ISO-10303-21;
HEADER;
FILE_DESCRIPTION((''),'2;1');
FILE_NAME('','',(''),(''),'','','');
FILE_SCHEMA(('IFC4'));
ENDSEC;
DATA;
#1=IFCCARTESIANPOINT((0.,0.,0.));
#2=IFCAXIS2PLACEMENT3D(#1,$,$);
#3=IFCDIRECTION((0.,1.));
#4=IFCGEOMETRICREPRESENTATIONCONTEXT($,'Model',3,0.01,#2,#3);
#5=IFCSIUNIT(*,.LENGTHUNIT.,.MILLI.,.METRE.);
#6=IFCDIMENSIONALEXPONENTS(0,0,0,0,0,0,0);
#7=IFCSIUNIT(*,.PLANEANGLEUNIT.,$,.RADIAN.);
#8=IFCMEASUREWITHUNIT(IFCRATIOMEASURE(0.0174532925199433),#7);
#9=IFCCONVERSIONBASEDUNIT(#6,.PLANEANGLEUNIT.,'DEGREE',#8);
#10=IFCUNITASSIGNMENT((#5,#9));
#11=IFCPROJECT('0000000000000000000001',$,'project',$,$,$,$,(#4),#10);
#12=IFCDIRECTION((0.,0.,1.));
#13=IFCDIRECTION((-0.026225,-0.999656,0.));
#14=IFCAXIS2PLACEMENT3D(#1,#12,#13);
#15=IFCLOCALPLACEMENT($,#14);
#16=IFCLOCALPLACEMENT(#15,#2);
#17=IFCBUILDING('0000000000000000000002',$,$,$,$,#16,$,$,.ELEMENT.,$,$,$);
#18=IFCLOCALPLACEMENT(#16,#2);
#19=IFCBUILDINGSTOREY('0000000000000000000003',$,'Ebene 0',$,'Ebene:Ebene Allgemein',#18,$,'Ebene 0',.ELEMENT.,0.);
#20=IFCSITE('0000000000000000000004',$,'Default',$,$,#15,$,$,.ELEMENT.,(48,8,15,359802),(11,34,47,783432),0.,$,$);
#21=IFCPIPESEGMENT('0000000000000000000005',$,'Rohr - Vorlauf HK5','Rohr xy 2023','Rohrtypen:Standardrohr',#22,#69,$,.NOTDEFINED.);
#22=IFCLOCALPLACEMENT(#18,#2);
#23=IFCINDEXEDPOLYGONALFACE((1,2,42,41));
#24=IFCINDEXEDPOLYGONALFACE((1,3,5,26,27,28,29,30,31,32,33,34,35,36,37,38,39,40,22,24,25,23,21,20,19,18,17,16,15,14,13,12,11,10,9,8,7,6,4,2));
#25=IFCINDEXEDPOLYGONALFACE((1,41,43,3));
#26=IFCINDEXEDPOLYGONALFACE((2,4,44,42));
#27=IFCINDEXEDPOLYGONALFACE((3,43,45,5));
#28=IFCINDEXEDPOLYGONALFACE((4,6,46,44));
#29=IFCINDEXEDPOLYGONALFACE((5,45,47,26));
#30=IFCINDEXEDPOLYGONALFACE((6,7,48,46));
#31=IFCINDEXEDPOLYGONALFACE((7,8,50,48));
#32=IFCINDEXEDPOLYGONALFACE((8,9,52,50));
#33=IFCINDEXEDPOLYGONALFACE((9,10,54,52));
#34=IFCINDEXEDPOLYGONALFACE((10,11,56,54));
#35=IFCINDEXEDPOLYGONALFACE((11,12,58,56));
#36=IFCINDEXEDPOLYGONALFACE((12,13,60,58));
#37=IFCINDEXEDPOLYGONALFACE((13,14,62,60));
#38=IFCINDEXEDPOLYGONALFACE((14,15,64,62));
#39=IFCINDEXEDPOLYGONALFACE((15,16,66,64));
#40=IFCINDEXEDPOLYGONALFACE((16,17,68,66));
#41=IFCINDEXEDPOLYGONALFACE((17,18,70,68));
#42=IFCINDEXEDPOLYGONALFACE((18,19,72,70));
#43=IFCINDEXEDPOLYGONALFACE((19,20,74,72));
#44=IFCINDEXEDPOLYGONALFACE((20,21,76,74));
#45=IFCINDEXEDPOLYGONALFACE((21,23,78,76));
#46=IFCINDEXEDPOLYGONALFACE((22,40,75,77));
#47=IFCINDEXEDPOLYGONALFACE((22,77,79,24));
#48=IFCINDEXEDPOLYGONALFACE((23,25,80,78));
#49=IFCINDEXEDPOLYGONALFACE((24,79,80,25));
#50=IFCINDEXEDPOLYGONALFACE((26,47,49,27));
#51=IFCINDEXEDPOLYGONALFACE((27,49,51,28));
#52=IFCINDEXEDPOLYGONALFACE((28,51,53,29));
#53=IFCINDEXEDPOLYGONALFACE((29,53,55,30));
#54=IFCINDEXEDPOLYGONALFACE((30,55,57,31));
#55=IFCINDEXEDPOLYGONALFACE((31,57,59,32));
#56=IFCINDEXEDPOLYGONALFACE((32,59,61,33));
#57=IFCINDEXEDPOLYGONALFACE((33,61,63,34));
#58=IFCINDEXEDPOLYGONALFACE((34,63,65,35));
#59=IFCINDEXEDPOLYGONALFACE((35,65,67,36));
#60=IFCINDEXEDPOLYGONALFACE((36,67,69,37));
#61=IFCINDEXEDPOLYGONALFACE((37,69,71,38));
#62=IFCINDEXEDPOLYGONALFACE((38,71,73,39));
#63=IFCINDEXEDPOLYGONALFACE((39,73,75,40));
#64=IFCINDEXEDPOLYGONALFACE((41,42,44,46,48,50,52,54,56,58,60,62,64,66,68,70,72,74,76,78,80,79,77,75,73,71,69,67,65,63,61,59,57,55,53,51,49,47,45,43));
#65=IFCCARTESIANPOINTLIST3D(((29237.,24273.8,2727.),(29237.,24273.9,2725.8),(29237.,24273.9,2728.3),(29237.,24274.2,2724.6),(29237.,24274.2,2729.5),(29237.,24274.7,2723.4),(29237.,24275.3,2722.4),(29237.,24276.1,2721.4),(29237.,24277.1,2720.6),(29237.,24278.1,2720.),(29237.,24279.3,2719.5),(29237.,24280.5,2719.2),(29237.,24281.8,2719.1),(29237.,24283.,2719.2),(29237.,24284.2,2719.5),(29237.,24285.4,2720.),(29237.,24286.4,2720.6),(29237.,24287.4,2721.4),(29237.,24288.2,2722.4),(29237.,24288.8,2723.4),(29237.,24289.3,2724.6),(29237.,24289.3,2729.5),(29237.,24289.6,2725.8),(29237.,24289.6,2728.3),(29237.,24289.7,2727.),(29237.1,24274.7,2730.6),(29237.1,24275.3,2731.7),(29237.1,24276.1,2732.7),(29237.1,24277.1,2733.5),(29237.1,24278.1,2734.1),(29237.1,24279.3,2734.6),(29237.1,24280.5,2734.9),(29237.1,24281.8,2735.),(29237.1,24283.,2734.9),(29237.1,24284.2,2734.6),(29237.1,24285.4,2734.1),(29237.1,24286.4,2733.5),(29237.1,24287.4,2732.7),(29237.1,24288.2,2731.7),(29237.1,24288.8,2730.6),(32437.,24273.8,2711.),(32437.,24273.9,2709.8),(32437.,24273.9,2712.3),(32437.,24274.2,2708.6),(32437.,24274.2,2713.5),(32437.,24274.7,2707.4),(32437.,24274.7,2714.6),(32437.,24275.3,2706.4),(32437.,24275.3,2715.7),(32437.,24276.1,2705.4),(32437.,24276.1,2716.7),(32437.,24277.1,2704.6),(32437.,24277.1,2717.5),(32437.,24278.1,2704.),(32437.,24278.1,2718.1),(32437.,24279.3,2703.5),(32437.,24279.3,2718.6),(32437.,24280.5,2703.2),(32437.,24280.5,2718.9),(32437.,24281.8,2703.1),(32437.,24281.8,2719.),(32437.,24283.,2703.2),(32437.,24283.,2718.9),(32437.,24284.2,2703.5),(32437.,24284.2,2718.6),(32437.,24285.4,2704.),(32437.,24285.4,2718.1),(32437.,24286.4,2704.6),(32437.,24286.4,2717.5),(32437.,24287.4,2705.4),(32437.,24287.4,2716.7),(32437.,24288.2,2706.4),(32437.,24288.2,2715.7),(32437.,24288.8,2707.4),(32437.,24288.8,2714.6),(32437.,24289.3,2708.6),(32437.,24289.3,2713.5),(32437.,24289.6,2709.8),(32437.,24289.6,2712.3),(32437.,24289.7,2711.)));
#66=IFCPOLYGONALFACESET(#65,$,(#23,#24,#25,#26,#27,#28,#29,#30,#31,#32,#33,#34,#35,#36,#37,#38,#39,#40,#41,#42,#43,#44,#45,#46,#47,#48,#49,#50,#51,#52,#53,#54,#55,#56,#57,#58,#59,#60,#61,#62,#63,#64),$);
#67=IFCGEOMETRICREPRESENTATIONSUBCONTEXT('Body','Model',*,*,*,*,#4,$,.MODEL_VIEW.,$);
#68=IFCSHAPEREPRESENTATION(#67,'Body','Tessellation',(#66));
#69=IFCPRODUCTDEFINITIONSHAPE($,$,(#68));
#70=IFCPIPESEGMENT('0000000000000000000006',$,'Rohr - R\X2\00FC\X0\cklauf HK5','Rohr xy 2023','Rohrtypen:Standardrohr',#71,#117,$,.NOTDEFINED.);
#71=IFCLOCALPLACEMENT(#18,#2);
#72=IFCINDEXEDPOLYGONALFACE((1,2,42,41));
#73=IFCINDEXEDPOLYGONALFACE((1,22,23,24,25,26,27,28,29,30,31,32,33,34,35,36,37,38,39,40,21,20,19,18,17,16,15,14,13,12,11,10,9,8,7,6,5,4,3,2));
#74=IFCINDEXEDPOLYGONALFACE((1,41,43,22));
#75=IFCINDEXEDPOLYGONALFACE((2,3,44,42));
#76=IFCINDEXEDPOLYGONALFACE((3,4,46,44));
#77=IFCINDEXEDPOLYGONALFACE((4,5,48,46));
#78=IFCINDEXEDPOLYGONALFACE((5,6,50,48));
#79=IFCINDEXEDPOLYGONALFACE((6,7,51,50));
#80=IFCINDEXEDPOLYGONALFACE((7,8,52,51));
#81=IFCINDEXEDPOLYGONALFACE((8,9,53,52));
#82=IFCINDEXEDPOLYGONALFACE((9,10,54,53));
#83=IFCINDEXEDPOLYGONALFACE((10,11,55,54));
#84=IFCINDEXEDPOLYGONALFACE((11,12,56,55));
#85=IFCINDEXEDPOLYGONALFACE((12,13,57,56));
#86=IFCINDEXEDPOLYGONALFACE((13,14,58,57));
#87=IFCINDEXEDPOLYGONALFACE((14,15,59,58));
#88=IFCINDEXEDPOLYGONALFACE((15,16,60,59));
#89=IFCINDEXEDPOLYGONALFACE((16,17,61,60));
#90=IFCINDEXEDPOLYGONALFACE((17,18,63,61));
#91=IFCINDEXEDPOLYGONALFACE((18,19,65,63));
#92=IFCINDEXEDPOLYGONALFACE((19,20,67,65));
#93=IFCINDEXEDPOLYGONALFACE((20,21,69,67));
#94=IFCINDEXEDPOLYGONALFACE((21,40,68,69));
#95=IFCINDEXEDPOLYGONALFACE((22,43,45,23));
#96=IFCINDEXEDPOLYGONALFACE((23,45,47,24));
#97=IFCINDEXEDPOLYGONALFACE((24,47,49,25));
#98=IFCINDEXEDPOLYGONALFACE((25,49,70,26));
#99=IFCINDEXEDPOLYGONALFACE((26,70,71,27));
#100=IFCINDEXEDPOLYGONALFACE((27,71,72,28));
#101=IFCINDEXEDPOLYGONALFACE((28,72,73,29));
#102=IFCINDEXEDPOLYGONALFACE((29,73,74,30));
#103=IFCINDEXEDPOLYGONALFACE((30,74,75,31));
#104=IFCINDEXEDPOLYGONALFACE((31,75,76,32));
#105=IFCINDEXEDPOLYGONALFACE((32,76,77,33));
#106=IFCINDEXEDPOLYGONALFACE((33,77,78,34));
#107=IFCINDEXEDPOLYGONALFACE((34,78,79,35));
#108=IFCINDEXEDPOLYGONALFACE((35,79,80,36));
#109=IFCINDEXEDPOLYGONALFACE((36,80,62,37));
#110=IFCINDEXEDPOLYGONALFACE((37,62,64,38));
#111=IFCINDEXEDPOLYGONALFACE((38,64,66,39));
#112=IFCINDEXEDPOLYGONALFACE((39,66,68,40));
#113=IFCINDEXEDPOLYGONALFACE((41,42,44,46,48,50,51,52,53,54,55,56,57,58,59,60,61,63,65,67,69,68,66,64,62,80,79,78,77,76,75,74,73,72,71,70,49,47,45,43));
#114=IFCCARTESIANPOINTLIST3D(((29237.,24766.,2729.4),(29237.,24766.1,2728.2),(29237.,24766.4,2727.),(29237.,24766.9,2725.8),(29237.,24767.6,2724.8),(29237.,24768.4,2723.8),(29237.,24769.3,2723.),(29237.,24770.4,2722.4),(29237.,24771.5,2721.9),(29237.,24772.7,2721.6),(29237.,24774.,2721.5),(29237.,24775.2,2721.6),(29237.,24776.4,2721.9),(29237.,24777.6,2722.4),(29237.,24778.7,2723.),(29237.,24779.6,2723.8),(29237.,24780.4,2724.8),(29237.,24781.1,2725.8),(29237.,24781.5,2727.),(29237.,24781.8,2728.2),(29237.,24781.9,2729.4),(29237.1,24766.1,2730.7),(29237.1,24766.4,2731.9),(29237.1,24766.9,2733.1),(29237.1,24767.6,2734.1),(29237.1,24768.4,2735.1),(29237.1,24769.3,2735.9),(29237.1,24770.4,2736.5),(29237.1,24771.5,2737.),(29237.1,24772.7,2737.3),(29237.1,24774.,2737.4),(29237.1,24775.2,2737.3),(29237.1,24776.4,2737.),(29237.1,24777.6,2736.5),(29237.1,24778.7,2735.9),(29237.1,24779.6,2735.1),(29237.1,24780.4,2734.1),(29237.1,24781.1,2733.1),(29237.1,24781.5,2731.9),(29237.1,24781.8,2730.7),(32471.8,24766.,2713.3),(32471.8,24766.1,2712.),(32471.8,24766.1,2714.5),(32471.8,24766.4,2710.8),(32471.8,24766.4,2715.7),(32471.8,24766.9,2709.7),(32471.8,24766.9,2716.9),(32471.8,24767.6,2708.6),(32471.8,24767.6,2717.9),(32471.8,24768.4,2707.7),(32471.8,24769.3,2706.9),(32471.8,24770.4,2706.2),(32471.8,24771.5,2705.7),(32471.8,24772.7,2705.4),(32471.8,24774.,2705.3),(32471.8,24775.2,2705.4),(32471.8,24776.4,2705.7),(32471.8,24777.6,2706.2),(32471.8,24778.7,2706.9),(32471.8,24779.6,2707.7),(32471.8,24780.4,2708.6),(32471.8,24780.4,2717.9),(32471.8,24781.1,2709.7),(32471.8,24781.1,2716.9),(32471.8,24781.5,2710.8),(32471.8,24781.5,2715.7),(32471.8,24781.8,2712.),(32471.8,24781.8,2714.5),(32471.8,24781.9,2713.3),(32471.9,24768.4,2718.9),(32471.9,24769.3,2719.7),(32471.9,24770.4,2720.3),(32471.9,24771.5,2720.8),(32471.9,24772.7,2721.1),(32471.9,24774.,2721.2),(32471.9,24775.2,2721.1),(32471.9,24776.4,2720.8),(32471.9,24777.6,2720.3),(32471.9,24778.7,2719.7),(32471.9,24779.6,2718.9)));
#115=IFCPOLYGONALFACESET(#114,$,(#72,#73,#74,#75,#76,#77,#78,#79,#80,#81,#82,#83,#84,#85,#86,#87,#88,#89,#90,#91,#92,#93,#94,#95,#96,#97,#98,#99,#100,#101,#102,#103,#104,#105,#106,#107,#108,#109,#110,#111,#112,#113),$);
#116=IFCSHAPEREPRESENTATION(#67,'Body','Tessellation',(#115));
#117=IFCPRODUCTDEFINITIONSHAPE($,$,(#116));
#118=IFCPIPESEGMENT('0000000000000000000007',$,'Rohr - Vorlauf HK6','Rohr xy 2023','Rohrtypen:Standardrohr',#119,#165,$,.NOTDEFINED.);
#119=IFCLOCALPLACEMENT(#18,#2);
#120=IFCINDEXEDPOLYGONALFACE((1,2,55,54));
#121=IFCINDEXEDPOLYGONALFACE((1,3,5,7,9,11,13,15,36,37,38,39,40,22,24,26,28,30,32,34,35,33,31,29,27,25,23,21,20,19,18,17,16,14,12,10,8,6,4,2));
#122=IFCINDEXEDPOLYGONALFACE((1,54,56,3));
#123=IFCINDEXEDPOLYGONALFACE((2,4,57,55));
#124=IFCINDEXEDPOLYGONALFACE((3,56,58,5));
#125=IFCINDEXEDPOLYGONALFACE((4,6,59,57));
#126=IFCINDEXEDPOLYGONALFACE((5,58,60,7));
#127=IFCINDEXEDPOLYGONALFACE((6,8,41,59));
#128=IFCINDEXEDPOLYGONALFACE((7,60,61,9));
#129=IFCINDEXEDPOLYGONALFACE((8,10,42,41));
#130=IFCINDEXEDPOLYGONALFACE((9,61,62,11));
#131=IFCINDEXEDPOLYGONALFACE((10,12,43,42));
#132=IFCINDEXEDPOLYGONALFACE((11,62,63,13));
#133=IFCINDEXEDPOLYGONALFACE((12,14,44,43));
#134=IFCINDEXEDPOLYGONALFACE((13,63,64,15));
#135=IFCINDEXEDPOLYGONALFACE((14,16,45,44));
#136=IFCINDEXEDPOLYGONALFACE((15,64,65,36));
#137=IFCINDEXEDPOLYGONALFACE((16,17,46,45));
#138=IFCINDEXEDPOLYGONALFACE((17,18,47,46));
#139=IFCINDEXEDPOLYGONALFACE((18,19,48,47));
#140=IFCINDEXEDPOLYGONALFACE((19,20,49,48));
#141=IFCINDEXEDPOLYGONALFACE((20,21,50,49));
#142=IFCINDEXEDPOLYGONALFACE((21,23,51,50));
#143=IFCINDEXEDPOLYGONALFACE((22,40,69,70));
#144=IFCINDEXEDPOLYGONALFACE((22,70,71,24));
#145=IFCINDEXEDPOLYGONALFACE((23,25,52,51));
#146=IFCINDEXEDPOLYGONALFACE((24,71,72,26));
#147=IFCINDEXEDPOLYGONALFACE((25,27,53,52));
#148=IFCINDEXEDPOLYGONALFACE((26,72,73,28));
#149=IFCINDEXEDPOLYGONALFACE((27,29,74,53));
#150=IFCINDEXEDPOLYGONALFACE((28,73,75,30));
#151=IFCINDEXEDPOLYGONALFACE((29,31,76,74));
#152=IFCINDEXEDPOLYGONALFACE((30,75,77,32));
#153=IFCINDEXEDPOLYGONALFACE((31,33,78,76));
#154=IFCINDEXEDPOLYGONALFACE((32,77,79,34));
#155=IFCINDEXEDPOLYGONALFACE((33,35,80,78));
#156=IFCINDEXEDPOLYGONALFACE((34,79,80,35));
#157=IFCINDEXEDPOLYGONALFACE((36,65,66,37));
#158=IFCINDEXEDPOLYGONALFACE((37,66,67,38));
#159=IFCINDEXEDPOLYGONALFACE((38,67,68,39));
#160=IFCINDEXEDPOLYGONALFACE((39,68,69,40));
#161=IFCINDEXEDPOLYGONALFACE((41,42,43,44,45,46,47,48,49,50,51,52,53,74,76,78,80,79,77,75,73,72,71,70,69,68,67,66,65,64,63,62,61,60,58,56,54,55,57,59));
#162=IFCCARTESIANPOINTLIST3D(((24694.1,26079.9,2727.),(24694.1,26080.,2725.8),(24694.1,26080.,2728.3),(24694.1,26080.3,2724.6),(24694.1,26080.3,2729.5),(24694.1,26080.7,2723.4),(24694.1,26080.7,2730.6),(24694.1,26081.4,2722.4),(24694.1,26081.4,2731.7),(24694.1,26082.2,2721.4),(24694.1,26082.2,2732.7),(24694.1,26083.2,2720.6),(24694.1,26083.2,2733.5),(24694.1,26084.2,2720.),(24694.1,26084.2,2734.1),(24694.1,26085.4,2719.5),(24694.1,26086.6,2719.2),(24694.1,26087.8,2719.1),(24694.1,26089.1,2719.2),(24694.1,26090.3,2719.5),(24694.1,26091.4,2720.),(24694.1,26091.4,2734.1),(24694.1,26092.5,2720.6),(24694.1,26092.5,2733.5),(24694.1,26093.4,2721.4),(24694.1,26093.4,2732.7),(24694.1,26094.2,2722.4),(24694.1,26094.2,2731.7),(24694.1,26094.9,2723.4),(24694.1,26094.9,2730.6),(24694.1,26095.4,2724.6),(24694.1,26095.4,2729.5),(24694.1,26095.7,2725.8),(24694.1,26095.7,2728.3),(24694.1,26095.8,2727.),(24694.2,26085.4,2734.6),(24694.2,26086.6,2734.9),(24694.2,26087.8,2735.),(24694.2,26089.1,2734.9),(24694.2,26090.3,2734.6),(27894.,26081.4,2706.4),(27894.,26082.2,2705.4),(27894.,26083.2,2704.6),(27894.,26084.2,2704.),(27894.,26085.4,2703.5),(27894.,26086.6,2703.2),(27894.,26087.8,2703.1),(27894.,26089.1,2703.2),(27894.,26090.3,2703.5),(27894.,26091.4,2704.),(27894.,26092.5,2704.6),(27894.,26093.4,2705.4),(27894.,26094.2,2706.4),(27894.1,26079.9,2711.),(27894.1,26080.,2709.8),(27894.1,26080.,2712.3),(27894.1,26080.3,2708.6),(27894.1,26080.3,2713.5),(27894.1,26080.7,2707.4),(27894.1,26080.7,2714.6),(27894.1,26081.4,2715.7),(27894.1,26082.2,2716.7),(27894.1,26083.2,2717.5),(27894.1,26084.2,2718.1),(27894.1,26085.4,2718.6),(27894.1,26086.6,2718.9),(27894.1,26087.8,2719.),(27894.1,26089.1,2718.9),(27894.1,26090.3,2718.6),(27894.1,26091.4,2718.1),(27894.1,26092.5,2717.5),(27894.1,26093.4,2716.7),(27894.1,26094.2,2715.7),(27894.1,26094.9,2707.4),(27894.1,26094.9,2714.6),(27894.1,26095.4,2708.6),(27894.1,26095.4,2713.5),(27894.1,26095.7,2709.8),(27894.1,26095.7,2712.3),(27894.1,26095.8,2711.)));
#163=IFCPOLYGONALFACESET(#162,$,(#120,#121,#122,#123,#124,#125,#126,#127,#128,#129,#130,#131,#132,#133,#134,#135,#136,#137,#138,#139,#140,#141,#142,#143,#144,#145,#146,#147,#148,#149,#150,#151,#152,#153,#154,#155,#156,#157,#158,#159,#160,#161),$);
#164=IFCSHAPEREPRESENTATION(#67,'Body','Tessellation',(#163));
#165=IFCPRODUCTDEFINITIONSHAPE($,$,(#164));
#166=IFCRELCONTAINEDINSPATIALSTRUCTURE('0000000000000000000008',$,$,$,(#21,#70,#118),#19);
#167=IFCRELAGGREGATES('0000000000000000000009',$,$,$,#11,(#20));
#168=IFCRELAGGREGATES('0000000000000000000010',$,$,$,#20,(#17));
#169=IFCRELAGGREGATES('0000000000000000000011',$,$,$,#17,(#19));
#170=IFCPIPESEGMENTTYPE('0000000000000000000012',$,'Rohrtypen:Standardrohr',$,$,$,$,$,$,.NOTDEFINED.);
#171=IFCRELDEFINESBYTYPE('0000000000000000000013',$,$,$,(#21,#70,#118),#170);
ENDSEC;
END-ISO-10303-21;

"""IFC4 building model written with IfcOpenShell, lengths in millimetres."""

from ifc_helpers import new_model, entity, si_unit, converted_unit, direction, frame, origin, place, context, subcontext, project, spatial, indexed_curve, outline, extrude, type_object, element, save


model = new_model("IFC4")

# Units and contexts
model_context = context("Model", 3, precision=0.01, world=origin(), true_north=direction((0.0, 1.0)))
body_context = subcontext(model_context, "Body", "Model", "MODEL_VIEW")
ifc_project = project(units=[si_unit("LENGTHUNIT", "METRE", prefix="MILLI"), converted_unit("PLANEANGLEUNIT", "DEGREE", entity("IfcRatioMeasure", 0.0174532925199433), si_unit("PLANEANGLEUNIT", "RADIAN"), dimensions=[0, 0, 0, 0, 0, 0, 0])], contexts=[model_context])

# Site, building, storey
site_placement = place(None, frame((0.0, 0.0, 0.0), z_axis=(0.0, 0.0, 1.0), x_axis=(-0.026225, -0.999656, 0.0)))
site = spatial("IfcSite", under=ifc_project, at=site_placement, Name="Default", CompositionType="ELEMENT", RefLatitude=(48, 8, 15, 359802), RefLongitude=(11, 34, 47, 783432), RefElevation=0.0)
building_placement = place(site_placement, origin())
building = spatial("IfcBuilding", under=site, at=building_placement, CompositionType="ELEMENT")
storey_placement = place(building_placement, origin())
storey = spatial("IfcBuildingStorey", under=building, at=storey_placement, Name="Ebene 0", ObjectType="Ebene:Ebene Allgemein", LongName="Ebene 0", CompositionType="ELEMENT", Elevation=0.0)

# Pipe segments
pipe_segment_type = type_object("IfcPipeSegmentType", Name="Rohrtypen:Standardrohr", PredefinedType="NOTDEFINED")
pipe_segment_1_placement = place(storey_placement, origin())
element("IfcPipeSegment", 1, at=pipe_segment_1_placement, inside=storey, type_object=pipe_segment_type, Name="Rohr - Vorlauf HK5", Description="Rohr xy 2023", ObjectType="Rohrtypen:Standardrohr", PredefinedType="NOTDEFINED", context=body_context, shape_type="SweptSolid", body=[
    extrude(outline(indexed_curve([(7.9, 0.0), (7.8, 1.2), (7.6, 2.5), (7.1, 3.6), (6.4, 4.7), (5.6, 5.6), (4.7, 6.4), (3.6, 7.1), (2.5, 7.6), (1.2, 7.8), (0.0, 7.9), (-1.2, 7.8), (-2.5, 7.6), (-3.6, 7.1), (-4.7, 6.4), (-5.6, 5.6), (-6.4, 4.7), (-7.1, 3.6), (-7.6, 2.5), (-7.8, 1.2), (-7.9, 0.0), (-7.8, -1.2), (-7.6, -2.5), (-7.1, -3.6), (-6.4, -4.7), (-5.6, -5.6), (-4.7, -6.4), (-3.6, -7.1), (-2.5, -7.6), (-1.2, -7.8), (0.0, -7.9), (1.2, -7.8), (2.5, -7.6), (3.6, -7.1), (4.7, -6.4), (5.6, -5.6), (6.4, -4.7), (7.1, -3.6), (7.6, -2.5), (7.8, -1.2), (7.9, 0.0)], self_intersect=False)), frame((32437.0, 24281.8, 2711.0), z_axis=(-0.999988, 0.0, 0.005), x_axis=(0.0, 1.0, 0.0)), (0.0, 0.0, 1.0), 3200.0),
])
pipe_segment_2_placement = place(storey_placement, origin())
element("IfcPipeSegment", 2, at=pipe_segment_2_placement, inside=storey, type_object=pipe_segment_type, Name="Rohr - Rücklauf HK5", Description="Rohr xy 2023", ObjectType="Rohrtypen:Standardrohr", PredefinedType="NOTDEFINED", context=body_context, shape_type="SweptSolid", body=[
    extrude(outline(indexed_curve([(7.9, 0.0), (7.8, 1.2), (7.6, 2.5), (7.1, 3.6), (6.4, 4.7), (5.6, 5.6), (4.7, 6.4), (3.6, 7.1), (2.5, 7.6), (1.2, 7.8), (0.0, 7.9), (-1.2, 7.8), (-2.5, 7.6), (-3.6, 7.1), (-4.7, 6.4), (-5.6, 5.6), (-6.4, 4.7), (-7.1, 3.6), (-7.6, 2.5), (-7.8, 1.2), (-7.9, 0.0), (-7.8, -1.2), (-7.6, -2.5), (-7.1, -3.6), (-6.4, -4.7), (-5.6, -5.6), (-4.7, -6.4), (-3.6, -7.1), (-2.5, -7.6), (-1.2, -7.8), (0.0, -7.9), (1.2, -7.8), (2.5, -7.6), (3.6, -7.1), (4.7, -6.4), (5.6, -5.6), (6.4, -4.7), (7.1, -3.6), (7.6, -2.5), (7.8, -1.2), (7.9, 0.0)], self_intersect=False)), frame((32471.8, 24774.0, 2713.3), z_axis=(-0.999988, 0.0, 0.005), x_axis=(0.0, 1.0, 0.0)), (0.0, 0.0, 1.0), 3234.8),
])
pipe_segment_3_placement = place(storey_placement, origin())
element("IfcPipeSegment", 3, at=pipe_segment_3_placement, inside=storey, type_object=pipe_segment_type, Name="Rohr - Vorlauf HK6", Description="Rohr xy 2023", ObjectType="Rohrtypen:Standardrohr", PredefinedType="NOTDEFINED", context=body_context, shape_type="SweptSolid", body=[
    extrude(outline(indexed_curve([(7.9, 0.0), (7.8, 1.2), (7.6, 2.5), (7.1, 3.6), (6.4, 4.7), (5.6, 5.6), (4.7, 6.4), (3.6, 7.1), (2.5, 7.6), (1.2, 7.8), (0.0, 7.9), (-1.2, 7.8), (-2.5, 7.6), (-3.6, 7.1), (-4.7, 6.4), (-5.6, 5.6), (-6.4, 4.7), (-7.1, 3.6), (-7.6, 2.5), (-7.8, 1.2), (-7.9, 0.0), (-7.8, -1.2), (-7.6, -2.5), (-7.1, -3.6), (-6.4, -4.7), (-5.6, -5.6), (-4.7, -6.4), (-3.6, -7.1), (-2.5, -7.6), (-1.2, -7.8), (0.0, -7.9), (1.2, -7.8), (2.5, -7.6), (3.6, -7.1), (4.7, -6.4), (5.6, -5.6), (6.4, -4.7), (7.1, -3.6), (7.6, -2.5), (7.8, -1.2), (7.9, 0.0)], self_intersect=False)), frame((27894.1, 26087.8, 2711.0), z_axis=(-0.999988, 0.0, 0.005), x_axis=(0.0, 1.0, 0.0)), (0.0, 0.0, 1.0), 3200.0),
])

save(model, "model.ifc")
